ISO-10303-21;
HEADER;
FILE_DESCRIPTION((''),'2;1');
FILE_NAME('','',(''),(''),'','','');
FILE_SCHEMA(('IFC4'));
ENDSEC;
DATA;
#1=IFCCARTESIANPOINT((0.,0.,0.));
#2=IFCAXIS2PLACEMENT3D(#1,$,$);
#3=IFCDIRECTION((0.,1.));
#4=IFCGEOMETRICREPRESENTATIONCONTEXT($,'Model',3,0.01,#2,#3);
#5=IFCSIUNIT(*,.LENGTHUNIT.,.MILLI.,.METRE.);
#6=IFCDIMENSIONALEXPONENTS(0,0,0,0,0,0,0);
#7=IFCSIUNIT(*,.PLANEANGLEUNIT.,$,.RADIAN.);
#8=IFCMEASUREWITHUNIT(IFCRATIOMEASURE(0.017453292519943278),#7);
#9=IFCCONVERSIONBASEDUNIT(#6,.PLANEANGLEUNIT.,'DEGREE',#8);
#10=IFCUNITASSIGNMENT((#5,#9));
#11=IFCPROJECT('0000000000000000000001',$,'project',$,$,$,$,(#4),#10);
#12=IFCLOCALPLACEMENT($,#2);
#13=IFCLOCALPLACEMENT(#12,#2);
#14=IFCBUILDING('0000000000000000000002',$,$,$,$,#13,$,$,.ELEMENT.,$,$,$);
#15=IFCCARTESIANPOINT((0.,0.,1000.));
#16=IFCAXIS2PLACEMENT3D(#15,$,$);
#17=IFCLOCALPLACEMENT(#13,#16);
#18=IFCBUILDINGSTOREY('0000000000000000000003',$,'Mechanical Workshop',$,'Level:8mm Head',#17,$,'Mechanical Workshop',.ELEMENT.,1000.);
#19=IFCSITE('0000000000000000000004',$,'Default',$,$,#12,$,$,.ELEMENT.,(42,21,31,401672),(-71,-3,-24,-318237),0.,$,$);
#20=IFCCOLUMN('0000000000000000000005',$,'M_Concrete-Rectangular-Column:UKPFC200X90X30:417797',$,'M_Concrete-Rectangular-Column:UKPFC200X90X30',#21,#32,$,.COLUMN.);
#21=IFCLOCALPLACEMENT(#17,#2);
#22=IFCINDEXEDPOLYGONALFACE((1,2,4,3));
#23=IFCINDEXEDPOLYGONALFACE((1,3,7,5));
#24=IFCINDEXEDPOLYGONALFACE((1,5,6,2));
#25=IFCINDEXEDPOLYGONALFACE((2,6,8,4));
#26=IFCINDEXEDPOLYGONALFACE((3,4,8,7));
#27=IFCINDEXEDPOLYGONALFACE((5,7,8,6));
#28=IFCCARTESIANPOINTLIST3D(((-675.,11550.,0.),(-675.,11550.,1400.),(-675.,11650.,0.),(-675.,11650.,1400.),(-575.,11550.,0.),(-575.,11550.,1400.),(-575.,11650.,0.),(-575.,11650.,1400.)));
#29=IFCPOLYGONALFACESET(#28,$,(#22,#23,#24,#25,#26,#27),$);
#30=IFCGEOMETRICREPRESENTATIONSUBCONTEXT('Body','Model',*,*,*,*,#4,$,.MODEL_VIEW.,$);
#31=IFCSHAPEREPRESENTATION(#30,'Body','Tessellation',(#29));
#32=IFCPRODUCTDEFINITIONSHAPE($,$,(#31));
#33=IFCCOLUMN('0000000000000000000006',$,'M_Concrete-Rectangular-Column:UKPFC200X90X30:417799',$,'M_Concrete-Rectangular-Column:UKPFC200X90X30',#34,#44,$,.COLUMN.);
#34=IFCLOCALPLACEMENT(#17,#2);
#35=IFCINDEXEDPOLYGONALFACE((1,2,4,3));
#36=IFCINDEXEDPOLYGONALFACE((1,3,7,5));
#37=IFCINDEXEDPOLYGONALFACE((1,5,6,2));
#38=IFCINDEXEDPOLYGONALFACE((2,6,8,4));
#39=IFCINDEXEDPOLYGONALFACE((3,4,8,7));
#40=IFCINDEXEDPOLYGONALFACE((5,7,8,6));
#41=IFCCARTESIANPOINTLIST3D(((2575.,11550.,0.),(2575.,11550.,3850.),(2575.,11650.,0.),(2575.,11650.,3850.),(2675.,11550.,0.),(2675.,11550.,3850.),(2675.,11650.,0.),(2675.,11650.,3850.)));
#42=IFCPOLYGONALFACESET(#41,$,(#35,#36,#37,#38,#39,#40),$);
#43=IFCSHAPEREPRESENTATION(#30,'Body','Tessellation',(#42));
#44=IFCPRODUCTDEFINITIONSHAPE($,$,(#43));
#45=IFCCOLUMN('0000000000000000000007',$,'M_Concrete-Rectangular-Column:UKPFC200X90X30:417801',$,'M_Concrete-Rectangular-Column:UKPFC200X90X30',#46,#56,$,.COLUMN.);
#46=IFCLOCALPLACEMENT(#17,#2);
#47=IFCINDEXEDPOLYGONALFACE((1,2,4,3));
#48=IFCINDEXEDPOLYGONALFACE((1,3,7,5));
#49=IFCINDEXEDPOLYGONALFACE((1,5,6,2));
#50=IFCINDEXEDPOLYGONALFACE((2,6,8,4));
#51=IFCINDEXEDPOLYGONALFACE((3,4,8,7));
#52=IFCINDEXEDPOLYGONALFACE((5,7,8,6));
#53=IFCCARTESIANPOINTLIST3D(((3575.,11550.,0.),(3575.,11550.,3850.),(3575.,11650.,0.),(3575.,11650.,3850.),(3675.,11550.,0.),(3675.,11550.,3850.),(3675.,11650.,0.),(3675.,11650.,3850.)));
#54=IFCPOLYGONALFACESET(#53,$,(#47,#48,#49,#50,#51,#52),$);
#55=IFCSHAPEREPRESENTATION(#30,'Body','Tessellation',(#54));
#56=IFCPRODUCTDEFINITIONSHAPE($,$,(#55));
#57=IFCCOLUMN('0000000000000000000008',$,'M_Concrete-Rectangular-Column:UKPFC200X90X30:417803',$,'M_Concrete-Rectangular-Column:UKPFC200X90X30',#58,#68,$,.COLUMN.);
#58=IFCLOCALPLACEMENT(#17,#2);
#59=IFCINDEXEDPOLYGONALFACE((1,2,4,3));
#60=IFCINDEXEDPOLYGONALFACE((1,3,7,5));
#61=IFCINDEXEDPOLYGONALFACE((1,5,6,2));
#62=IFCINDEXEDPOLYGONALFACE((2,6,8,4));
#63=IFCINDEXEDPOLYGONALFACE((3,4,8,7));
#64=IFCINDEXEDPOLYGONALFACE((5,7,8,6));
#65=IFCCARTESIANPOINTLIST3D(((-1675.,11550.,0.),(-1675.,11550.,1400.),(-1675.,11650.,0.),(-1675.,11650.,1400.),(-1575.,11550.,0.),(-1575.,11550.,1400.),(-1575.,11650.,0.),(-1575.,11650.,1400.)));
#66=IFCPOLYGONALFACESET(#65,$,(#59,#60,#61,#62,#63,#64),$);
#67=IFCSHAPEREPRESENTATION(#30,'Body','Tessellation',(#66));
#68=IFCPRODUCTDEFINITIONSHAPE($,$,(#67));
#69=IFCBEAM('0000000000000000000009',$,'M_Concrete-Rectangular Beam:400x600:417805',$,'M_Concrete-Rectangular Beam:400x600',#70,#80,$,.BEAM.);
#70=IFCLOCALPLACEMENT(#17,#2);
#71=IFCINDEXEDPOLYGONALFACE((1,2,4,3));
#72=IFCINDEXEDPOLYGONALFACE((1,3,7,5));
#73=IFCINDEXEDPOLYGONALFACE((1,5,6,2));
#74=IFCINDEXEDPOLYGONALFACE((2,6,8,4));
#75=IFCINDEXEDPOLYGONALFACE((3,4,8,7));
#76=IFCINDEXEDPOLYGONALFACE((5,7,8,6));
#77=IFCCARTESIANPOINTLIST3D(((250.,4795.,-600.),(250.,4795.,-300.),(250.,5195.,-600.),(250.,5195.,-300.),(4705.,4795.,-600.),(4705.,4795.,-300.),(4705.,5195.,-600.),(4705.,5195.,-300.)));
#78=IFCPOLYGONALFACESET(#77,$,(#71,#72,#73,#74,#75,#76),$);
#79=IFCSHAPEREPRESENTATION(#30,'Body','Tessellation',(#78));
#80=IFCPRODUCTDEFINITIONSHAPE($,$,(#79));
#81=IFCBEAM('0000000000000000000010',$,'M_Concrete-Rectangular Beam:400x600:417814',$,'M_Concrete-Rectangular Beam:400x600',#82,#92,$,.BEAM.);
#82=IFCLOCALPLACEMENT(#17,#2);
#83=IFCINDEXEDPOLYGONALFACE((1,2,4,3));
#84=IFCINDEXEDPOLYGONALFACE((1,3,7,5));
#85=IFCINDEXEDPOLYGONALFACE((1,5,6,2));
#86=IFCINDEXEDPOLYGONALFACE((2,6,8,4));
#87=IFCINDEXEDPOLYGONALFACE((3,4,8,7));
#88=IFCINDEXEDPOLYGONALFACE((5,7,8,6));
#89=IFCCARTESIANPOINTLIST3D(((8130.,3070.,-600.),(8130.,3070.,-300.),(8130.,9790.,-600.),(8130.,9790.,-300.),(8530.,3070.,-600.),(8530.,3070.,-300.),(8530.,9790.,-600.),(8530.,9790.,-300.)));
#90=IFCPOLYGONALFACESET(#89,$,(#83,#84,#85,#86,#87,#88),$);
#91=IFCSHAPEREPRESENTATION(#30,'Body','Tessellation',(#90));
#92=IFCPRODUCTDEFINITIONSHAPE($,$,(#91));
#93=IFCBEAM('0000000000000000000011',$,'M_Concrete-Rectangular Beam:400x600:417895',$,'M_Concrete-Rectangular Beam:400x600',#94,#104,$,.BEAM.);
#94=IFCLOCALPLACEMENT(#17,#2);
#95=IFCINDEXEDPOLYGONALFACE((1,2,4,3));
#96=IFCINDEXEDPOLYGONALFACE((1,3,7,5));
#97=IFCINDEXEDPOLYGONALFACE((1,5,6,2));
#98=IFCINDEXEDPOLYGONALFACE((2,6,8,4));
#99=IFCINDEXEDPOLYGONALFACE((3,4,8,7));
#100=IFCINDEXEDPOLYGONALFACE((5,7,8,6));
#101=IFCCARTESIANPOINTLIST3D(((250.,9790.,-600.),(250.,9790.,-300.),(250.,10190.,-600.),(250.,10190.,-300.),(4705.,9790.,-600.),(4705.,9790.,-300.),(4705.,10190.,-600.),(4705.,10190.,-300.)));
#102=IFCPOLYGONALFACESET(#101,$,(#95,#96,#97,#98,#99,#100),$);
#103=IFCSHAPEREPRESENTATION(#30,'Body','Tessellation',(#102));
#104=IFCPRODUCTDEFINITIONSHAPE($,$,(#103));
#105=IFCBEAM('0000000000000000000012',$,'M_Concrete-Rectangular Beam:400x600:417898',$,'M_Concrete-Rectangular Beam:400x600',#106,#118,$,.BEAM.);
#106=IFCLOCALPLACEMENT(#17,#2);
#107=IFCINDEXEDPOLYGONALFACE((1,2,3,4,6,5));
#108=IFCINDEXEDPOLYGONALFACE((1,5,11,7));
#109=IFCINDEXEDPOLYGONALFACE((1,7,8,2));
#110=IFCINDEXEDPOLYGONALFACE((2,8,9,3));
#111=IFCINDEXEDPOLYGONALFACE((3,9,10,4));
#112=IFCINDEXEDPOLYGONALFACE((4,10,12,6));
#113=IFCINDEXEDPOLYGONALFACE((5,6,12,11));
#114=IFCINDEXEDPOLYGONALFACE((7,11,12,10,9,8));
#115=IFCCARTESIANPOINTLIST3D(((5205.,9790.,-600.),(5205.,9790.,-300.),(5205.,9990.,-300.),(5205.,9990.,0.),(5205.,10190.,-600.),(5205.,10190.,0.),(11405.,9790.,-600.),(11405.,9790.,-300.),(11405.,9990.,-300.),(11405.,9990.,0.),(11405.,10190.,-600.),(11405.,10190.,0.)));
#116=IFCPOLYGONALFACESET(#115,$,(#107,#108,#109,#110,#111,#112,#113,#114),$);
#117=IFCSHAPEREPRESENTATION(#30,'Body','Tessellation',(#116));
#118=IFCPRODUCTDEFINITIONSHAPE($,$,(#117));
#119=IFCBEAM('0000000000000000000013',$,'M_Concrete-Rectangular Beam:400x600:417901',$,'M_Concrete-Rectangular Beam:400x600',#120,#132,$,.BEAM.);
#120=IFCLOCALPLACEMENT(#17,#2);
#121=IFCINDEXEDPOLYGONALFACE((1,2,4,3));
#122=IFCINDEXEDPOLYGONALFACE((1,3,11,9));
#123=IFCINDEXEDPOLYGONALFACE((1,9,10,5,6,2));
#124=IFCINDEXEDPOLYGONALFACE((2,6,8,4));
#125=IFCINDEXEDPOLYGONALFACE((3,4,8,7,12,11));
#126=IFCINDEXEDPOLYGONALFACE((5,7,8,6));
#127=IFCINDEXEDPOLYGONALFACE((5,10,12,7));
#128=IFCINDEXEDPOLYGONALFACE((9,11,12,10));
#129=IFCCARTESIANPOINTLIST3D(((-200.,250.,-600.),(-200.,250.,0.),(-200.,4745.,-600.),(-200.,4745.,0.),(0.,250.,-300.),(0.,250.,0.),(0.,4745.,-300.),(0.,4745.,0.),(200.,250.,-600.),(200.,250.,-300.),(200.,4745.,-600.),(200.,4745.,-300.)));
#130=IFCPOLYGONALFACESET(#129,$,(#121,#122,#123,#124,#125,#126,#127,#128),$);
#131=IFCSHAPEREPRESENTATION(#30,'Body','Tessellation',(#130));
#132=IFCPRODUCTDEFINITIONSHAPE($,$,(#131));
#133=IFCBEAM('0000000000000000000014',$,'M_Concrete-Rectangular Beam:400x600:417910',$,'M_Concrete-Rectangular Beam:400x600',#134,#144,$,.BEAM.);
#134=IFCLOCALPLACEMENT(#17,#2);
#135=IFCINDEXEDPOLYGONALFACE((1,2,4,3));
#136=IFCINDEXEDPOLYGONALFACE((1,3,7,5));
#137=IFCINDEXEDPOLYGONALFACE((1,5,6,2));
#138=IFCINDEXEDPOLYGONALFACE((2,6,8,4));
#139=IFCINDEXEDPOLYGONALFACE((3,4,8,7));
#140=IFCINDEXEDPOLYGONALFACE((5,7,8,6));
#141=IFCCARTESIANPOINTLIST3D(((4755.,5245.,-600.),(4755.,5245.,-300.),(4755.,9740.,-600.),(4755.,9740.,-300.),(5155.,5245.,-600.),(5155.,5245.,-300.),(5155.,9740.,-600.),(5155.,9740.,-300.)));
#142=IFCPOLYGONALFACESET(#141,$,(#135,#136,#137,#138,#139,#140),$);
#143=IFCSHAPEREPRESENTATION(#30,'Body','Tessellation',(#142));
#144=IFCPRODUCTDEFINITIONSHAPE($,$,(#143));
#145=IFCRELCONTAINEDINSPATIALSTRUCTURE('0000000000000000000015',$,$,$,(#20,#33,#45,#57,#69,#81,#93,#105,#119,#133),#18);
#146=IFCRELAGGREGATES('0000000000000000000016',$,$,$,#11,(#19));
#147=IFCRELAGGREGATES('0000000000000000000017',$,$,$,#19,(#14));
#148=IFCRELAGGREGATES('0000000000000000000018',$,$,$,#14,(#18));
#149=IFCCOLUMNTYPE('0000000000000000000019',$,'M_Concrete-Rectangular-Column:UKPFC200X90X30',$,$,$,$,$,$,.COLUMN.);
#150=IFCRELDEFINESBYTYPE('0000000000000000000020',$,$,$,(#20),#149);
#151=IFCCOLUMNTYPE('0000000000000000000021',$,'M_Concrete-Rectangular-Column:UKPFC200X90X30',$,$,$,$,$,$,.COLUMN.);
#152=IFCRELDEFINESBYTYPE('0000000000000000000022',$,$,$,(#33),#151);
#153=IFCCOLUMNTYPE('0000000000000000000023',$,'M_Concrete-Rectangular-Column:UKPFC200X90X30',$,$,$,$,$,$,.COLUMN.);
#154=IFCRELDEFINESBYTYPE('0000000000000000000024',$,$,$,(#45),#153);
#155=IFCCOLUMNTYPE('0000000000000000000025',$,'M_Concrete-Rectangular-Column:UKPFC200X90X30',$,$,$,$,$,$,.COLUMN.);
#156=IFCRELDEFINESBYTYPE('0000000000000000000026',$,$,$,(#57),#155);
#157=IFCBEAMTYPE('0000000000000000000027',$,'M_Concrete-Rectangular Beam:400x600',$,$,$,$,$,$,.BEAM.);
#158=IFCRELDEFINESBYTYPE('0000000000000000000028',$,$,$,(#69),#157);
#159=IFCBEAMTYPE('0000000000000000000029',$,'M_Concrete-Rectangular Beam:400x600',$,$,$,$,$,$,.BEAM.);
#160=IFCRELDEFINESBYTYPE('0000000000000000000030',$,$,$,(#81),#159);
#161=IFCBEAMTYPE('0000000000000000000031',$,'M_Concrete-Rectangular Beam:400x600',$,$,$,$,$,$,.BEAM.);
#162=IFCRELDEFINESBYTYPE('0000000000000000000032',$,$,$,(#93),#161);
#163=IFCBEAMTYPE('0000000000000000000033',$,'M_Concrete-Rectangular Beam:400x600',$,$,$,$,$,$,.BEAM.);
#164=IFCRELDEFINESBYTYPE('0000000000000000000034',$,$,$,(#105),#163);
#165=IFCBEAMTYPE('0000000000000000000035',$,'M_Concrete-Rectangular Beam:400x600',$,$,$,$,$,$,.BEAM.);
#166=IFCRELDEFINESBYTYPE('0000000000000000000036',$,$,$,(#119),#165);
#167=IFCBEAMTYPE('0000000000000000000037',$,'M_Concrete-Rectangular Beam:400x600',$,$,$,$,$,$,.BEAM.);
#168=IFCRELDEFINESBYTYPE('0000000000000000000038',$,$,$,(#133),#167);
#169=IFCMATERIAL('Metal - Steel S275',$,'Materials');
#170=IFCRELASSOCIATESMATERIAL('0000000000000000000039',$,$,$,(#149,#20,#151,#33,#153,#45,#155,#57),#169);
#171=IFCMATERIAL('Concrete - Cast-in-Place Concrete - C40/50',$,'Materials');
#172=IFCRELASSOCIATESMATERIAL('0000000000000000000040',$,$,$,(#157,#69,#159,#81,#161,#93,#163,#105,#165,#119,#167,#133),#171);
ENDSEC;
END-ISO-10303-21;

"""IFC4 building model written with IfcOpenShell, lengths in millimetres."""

from ifc_helpers import new_model, entity, si_unit, converted_unit, direction, frame, origin, place, context, subcontext, project, spatial, indexed_curve, outline, extrude, source, transform, mapped, material, type_object, type_shapes, element, save


model = new_model("IFC4")

# Units and contexts
model_context = context("Model", 3, precision=0.01, world=origin(), true_north=direction((0.0, 1.0)))
body_context = subcontext(model_context, "Body", "Model", "MODEL_VIEW")
ifc_project = project(units=[si_unit("LENGTHUNIT", "METRE", prefix="MILLI"), converted_unit("PLANEANGLEUNIT", "DEGREE", entity("IfcRatioMeasure", 0.017453292519943278), si_unit("PLANEANGLEUNIT", "RADIAN"), dimensions=[0, 0, 0, 0, 0, 0, 0])], contexts=[model_context])

# Site, building, storey
site_placement = place(None, origin())
site = spatial("IfcSite", under=ifc_project, at=site_placement, Name="Default", CompositionType="ELEMENT", RefLatitude=(42, 21, 31, 401672), RefLongitude=(-71, -3, -24, -318237), RefElevation=0.0)
building_placement = place(site_placement, origin())
building = spatial("IfcBuilding", under=site, at=building_placement, CompositionType="ELEMENT")
storey_placement = place(building_placement, frame((0.0, 0.0, 1000.0)))
storey = spatial("IfcBuildingStorey", under=building, at=storey_placement, Name="Mechanical Workshop", ObjectType="Level:8mm Head", LongName="Mechanical Workshop", CompositionType="ELEMENT", Elevation=1000.0)

# Columns
ifc_material_1 = material(Name="Metal - Steel S275", Category="Materials")
column_type_1 = type_object("IfcColumnType", Name="M_Concrete-Rectangular-Column:UKPFC200X90X30", PredefinedType="COLUMN", material=ifc_material_1)
shared_shape_1 = source(origin(), body_context, "Body", "SweptSolid", [
    extrude(outline(indexed_curve([(-50.0, -50.0), (50.0, -50.0), (50.0, 50.0), (-50.0, 50.0), (-50.0, -50.0)], self_intersect=False)), frame((-625.0, 11600.0, 1000.0), z_axis=(0.0, 0.0, 1.0), x_axis=(0.0, -1.0, 0.0)), (0.0, 0.0, 1.0), 1400.0),
])
type_shapes(column_type_1, [shared_shape_1])
column_1_placement = place(storey_placement, frame((0.0, 0.0, -1000.0)))
element("IfcColumn", 1, at=column_1_placement, inside=storey, type_object=column_type_1, material=ifc_material_1, Name="M_Concrete-Rectangular-Column:UKPFC200X90X30:417797", ObjectType="M_Concrete-Rectangular-Column:UKPFC200X90X30", PredefinedType="COLUMN", context=body_context, shape_type="MappedRepresentation", body=[
    mapped(shared_shape_1, transform((0.0, 0.0, 0.0), scale=1.0)),
])
column_type_2 = type_object("IfcColumnType", Name="M_Concrete-Rectangular-Column:UKPFC200X90X30", PredefinedType="COLUMN", material=ifc_material_1)
shared_shape_2 = source(origin(), body_context, "Body", "SweptSolid", [
    extrude(outline(indexed_curve([(-50.0, -50.0), (50.0, -50.0), (50.0, 50.0), (-50.0, 50.0), (-50.0, -50.0)], self_intersect=False)), frame((2625.0, 11600.0, 1000.0), z_axis=(0.0, 0.0, 1.0), x_axis=(0.0, -1.0, 0.0)), (0.0, 0.0, 1.0), 3850.0),
])
type_shapes(column_type_2, [shared_shape_2])
column_2_placement = place(storey_placement, frame((0.0, 0.0, -1000.0)))
element("IfcColumn", 2, at=column_2_placement, inside=storey, type_object=column_type_2, material=ifc_material_1, Name="M_Concrete-Rectangular-Column:UKPFC200X90X30:417799", ObjectType="M_Concrete-Rectangular-Column:UKPFC200X90X30", PredefinedType="COLUMN", context=body_context, shape_type="MappedRepresentation", body=[
    mapped(shared_shape_2, transform((0.0, 0.0, 0.0), scale=1.0)),
])
column_type_3 = type_object("IfcColumnType", Name="M_Concrete-Rectangular-Column:UKPFC200X90X30", PredefinedType="COLUMN", material=ifc_material_1)
shared_shape_3 = source(origin(), body_context, "Body", "SweptSolid", [
    extrude(outline(indexed_curve([(-50.0, -50.0), (50.0, -50.0), (50.0, 50.0), (-50.0, 50.0), (-50.0, -50.0)], self_intersect=False)), frame((3625.0, 11600.0, 1000.0), z_axis=(0.0, 0.0, 1.0), x_axis=(0.0, -1.0, 0.0)), (0.0, 0.0, 1.0), 3850.0),
])
type_shapes(column_type_3, [shared_shape_3])
column_3_placement = place(storey_placement, frame((0.0, 0.0, -1000.0)))
element("IfcColumn", 3, at=column_3_placement, inside=storey, type_object=column_type_3, material=ifc_material_1, Name="M_Concrete-Rectangular-Column:UKPFC200X90X30:417801", ObjectType="M_Concrete-Rectangular-Column:UKPFC200X90X30", PredefinedType="COLUMN", context=body_context, shape_type="MappedRepresentation", body=[
    mapped(shared_shape_3, transform((0.0, 0.0, 0.0), scale=1.0)),
])
column_type_4 = type_object("IfcColumnType", Name="M_Concrete-Rectangular-Column:UKPFC200X90X30", PredefinedType="COLUMN", material=ifc_material_1)
shared_shape_4 = source(origin(), body_context, "Body", "SweptSolid", [
    extrude(outline(indexed_curve([(-50.0, -50.0), (50.0, -50.0), (50.0, 50.0), (-50.0, 50.0), (-50.0, -50.0)], self_intersect=False)), frame((-1625.0, 11600.0, 1000.0), z_axis=(0.0, 0.0, 1.0), x_axis=(0.0, -1.0, 0.0)), (0.0, 0.0, 1.0), 1400.0),
])
type_shapes(column_type_4, [shared_shape_4])
column_4_placement = place(storey_placement, frame((0.0, 0.0, -1000.0)))
element("IfcColumn", 4, at=column_4_placement, inside=storey, type_object=column_type_4, material=ifc_material_1, Name="M_Concrete-Rectangular-Column:UKPFC200X90X30:417803", ObjectType="M_Concrete-Rectangular-Column:UKPFC200X90X30", PredefinedType="COLUMN", context=body_context, shape_type="MappedRepresentation", body=[
    mapped(shared_shape_4, transform((0.0, 0.0, 0.0), scale=1.0)),
])

# Beams
ifc_material_2 = material(Name="Concrete - Cast-in-Place Concrete - C40/50", Category="Materials")
beam_type_1 = type_object("IfcBeamType", Name="M_Concrete-Rectangular Beam:400x600", PredefinedType="BEAM", material=ifc_material_2)
shared_shape_5 = source(origin(), body_context, "Body", "SweptSolid", [
    extrude(outline(indexed_curve([(-150.0, -200.0), (150.0, -200.0), (150.0, 200.0), (-150.0, 200.0), (-150.0, -200.0)], self_intersect=False)), frame((250.0, 4995.0, 550.0), z_axis=(1.0, 0.0, 0.0), x_axis=(0.0, 0.0, -1.0)), (0.0, 0.0, 1.0), 4455.0),
])
type_shapes(beam_type_1, [shared_shape_5])
beam_1_placement = place(storey_placement, frame((0.0, 0.0, -1000.0)))
element("IfcBeam", 5, at=beam_1_placement, inside=storey, type_object=beam_type_1, material=ifc_material_2, Name="M_Concrete-Rectangular Beam:400x600:417805", ObjectType="M_Concrete-Rectangular Beam:400x600", PredefinedType="BEAM", context=body_context, shape_type="MappedRepresentation", body=[
    mapped(shared_shape_5, transform((0.0, 0.0, 0.0), scale=1.0)),
])
beam_type_2 = type_object("IfcBeamType", Name="M_Concrete-Rectangular Beam:400x600", PredefinedType="BEAM", material=ifc_material_2)
shared_shape_6 = source(origin(), body_context, "Body", "SweptSolid", [
    extrude(outline(indexed_curve([(-200.0, -150.0), (200.0, -150.0), (200.0, 150.0), (-200.0, 150.0), (-200.0, -150.0)], self_intersect=False)), frame((8330.0, 3070.0, 550.0), z_axis=(0.0, 1.0, 0.0), x_axis=(-1.0, 0.0, 0.0)), (0.0, 0.0, 1.0), 6720.0),
])
type_shapes(beam_type_2, [shared_shape_6])
beam_2_placement = place(storey_placement, frame((0.0, 0.0, -1000.0)))
element("IfcBeam", 6, at=beam_2_placement, inside=storey, type_object=beam_type_2, material=ifc_material_2, Name="M_Concrete-Rectangular Beam:400x600:417814", ObjectType="M_Concrete-Rectangular Beam:400x600", PredefinedType="BEAM", context=body_context, shape_type="MappedRepresentation", body=[
    mapped(shared_shape_6, transform((0.0, 0.0, 0.0), scale=1.0)),
])
beam_type_3 = type_object("IfcBeamType", Name="M_Concrete-Rectangular Beam:400x600", PredefinedType="BEAM", material=ifc_material_2)
shared_shape_7 = source(origin(), body_context, "Body", "SweptSolid", [
    extrude(outline(indexed_curve([(-150.0, -200.0), (150.0, -200.0), (150.0, 200.0), (-150.0, 200.0), (-150.0, -200.0)], self_intersect=False)), frame((250.0, 9990.0, 550.0), z_axis=(1.0, 0.0, 0.0), x_axis=(0.0, 0.0, -1.0)), (0.0, 0.0, 1.0), 4455.0),
])
type_shapes(beam_type_3, [shared_shape_7])
beam_3_placement = place(storey_placement, frame((0.0, 0.0, -1000.0)))
element("IfcBeam", 7, at=beam_3_placement, inside=storey, type_object=beam_type_3, material=ifc_material_2, Name="M_Concrete-Rectangular Beam:400x600:417895", ObjectType="M_Concrete-Rectangular Beam:400x600", PredefinedType="BEAM", context=body_context, shape_type="MappedRepresentation", body=[
    mapped(shared_shape_7, transform((0.0, 0.0, 0.0), scale=1.0)),
])
beam_type_4 = type_object("IfcBeamType", Name="M_Concrete-Rectangular Beam:400x600", PredefinedType="BEAM", material=ifc_material_2)
shared_shape_8 = source(origin(), body_context, "Body", "SweptSolid", [
    extrude(outline(indexed_curve([(0.0, -200.0), (300.0, -200.0), (300.0, 200.0), (-300.0, 200.0), (-300.0, 0.0), (0.0, 0.0), (0.0, -200.0)], self_intersect=False)), frame((5205.0, 9990.0, 700.0), z_axis=(1.0, 0.0, 0.0), x_axis=(0.0, 0.0, -1.0)), (0.0, 0.0, 1.0), 6200.0),
])
type_shapes(beam_type_4, [shared_shape_8])
beam_4_placement = place(storey_placement, frame((0.0, 0.0, -1000.0)))
element("IfcBeam", 8, at=beam_4_placement, inside=storey, type_object=beam_type_4, material=ifc_material_2, Name="M_Concrete-Rectangular Beam:400x600:417898", ObjectType="M_Concrete-Rectangular Beam:400x600", PredefinedType="BEAM", context=body_context, shape_type="MappedRepresentation", body=[
    mapped(shared_shape_8, transform((0.0, 0.0, 0.0), scale=1.0)),
])
beam_type_5 = type_object("IfcBeamType", Name="M_Concrete-Rectangular Beam:400x600", PredefinedType="BEAM", material=ifc_material_2)
shared_shape_9 = source(origin(), body_context, "Body", "SweptSolid", [
    extrude(outline(indexed_curve([(-200.0, -300.0), (200.0, -300.0), (200.0, 300.0), (0.0, 300.0), (0.0, 0.0), (-200.0, 0.0), (-200.0, -300.0)], self_intersect=False)), frame((0.0, 250.0, 700.0), z_axis=(0.0, 1.0, 0.0), x_axis=(-1.0, 0.0, 0.0)), (0.0, 0.0, 1.0), 4495.0),
])
type_shapes(beam_type_5, [shared_shape_9])
beam_5_placement = place(storey_placement, frame((0.0, 0.0, -1000.0)))
element("IfcBeam", 9, at=beam_5_placement, inside=storey, type_object=beam_type_5, material=ifc_material_2, Name="M_Concrete-Rectangular Beam:400x600:417901", ObjectType="M_Concrete-Rectangular Beam:400x600", PredefinedType="BEAM", context=body_context, shape_type="MappedRepresentation", body=[
    mapped(shared_shape_9, transform((0.0, 0.0, 0.0), scale=1.0)),
])
beam_type_6 = type_object("IfcBeamType", Name="M_Concrete-Rectangular Beam:400x600", PredefinedType="BEAM", material=ifc_material_2)
shared_shape_10 = source(origin(), body_context, "Body", "SweptSolid", [
    extrude(outline(indexed_curve([(-200.0, -150.0), (200.0, -150.0), (200.0, 150.0), (-200.0, 150.0), (-200.0, -150.0)], self_intersect=False)), frame((4955.0, 5245.0, 550.0), z_axis=(0.0, 1.0, 0.0), x_axis=(-1.0, 0.0, 0.0)), (0.0, 0.0, 1.0), 4495.0),
])
type_shapes(beam_type_6, [shared_shape_10])
beam_6_placement = place(storey_placement, frame((0.0, 0.0, -1000.0)))
element("IfcBeam", 10, at=beam_6_placement, inside=storey, type_object=beam_type_6, material=ifc_material_2, Name="M_Concrete-Rectangular Beam:400x600:417910", ObjectType="M_Concrete-Rectangular Beam:400x600", PredefinedType="BEAM", context=body_context, shape_type="MappedRepresentation", body=[
    mapped(shared_shape_10, transform((0.0, 0.0, 0.0), scale=1.0)),
])

save(model, "model.ifc")
